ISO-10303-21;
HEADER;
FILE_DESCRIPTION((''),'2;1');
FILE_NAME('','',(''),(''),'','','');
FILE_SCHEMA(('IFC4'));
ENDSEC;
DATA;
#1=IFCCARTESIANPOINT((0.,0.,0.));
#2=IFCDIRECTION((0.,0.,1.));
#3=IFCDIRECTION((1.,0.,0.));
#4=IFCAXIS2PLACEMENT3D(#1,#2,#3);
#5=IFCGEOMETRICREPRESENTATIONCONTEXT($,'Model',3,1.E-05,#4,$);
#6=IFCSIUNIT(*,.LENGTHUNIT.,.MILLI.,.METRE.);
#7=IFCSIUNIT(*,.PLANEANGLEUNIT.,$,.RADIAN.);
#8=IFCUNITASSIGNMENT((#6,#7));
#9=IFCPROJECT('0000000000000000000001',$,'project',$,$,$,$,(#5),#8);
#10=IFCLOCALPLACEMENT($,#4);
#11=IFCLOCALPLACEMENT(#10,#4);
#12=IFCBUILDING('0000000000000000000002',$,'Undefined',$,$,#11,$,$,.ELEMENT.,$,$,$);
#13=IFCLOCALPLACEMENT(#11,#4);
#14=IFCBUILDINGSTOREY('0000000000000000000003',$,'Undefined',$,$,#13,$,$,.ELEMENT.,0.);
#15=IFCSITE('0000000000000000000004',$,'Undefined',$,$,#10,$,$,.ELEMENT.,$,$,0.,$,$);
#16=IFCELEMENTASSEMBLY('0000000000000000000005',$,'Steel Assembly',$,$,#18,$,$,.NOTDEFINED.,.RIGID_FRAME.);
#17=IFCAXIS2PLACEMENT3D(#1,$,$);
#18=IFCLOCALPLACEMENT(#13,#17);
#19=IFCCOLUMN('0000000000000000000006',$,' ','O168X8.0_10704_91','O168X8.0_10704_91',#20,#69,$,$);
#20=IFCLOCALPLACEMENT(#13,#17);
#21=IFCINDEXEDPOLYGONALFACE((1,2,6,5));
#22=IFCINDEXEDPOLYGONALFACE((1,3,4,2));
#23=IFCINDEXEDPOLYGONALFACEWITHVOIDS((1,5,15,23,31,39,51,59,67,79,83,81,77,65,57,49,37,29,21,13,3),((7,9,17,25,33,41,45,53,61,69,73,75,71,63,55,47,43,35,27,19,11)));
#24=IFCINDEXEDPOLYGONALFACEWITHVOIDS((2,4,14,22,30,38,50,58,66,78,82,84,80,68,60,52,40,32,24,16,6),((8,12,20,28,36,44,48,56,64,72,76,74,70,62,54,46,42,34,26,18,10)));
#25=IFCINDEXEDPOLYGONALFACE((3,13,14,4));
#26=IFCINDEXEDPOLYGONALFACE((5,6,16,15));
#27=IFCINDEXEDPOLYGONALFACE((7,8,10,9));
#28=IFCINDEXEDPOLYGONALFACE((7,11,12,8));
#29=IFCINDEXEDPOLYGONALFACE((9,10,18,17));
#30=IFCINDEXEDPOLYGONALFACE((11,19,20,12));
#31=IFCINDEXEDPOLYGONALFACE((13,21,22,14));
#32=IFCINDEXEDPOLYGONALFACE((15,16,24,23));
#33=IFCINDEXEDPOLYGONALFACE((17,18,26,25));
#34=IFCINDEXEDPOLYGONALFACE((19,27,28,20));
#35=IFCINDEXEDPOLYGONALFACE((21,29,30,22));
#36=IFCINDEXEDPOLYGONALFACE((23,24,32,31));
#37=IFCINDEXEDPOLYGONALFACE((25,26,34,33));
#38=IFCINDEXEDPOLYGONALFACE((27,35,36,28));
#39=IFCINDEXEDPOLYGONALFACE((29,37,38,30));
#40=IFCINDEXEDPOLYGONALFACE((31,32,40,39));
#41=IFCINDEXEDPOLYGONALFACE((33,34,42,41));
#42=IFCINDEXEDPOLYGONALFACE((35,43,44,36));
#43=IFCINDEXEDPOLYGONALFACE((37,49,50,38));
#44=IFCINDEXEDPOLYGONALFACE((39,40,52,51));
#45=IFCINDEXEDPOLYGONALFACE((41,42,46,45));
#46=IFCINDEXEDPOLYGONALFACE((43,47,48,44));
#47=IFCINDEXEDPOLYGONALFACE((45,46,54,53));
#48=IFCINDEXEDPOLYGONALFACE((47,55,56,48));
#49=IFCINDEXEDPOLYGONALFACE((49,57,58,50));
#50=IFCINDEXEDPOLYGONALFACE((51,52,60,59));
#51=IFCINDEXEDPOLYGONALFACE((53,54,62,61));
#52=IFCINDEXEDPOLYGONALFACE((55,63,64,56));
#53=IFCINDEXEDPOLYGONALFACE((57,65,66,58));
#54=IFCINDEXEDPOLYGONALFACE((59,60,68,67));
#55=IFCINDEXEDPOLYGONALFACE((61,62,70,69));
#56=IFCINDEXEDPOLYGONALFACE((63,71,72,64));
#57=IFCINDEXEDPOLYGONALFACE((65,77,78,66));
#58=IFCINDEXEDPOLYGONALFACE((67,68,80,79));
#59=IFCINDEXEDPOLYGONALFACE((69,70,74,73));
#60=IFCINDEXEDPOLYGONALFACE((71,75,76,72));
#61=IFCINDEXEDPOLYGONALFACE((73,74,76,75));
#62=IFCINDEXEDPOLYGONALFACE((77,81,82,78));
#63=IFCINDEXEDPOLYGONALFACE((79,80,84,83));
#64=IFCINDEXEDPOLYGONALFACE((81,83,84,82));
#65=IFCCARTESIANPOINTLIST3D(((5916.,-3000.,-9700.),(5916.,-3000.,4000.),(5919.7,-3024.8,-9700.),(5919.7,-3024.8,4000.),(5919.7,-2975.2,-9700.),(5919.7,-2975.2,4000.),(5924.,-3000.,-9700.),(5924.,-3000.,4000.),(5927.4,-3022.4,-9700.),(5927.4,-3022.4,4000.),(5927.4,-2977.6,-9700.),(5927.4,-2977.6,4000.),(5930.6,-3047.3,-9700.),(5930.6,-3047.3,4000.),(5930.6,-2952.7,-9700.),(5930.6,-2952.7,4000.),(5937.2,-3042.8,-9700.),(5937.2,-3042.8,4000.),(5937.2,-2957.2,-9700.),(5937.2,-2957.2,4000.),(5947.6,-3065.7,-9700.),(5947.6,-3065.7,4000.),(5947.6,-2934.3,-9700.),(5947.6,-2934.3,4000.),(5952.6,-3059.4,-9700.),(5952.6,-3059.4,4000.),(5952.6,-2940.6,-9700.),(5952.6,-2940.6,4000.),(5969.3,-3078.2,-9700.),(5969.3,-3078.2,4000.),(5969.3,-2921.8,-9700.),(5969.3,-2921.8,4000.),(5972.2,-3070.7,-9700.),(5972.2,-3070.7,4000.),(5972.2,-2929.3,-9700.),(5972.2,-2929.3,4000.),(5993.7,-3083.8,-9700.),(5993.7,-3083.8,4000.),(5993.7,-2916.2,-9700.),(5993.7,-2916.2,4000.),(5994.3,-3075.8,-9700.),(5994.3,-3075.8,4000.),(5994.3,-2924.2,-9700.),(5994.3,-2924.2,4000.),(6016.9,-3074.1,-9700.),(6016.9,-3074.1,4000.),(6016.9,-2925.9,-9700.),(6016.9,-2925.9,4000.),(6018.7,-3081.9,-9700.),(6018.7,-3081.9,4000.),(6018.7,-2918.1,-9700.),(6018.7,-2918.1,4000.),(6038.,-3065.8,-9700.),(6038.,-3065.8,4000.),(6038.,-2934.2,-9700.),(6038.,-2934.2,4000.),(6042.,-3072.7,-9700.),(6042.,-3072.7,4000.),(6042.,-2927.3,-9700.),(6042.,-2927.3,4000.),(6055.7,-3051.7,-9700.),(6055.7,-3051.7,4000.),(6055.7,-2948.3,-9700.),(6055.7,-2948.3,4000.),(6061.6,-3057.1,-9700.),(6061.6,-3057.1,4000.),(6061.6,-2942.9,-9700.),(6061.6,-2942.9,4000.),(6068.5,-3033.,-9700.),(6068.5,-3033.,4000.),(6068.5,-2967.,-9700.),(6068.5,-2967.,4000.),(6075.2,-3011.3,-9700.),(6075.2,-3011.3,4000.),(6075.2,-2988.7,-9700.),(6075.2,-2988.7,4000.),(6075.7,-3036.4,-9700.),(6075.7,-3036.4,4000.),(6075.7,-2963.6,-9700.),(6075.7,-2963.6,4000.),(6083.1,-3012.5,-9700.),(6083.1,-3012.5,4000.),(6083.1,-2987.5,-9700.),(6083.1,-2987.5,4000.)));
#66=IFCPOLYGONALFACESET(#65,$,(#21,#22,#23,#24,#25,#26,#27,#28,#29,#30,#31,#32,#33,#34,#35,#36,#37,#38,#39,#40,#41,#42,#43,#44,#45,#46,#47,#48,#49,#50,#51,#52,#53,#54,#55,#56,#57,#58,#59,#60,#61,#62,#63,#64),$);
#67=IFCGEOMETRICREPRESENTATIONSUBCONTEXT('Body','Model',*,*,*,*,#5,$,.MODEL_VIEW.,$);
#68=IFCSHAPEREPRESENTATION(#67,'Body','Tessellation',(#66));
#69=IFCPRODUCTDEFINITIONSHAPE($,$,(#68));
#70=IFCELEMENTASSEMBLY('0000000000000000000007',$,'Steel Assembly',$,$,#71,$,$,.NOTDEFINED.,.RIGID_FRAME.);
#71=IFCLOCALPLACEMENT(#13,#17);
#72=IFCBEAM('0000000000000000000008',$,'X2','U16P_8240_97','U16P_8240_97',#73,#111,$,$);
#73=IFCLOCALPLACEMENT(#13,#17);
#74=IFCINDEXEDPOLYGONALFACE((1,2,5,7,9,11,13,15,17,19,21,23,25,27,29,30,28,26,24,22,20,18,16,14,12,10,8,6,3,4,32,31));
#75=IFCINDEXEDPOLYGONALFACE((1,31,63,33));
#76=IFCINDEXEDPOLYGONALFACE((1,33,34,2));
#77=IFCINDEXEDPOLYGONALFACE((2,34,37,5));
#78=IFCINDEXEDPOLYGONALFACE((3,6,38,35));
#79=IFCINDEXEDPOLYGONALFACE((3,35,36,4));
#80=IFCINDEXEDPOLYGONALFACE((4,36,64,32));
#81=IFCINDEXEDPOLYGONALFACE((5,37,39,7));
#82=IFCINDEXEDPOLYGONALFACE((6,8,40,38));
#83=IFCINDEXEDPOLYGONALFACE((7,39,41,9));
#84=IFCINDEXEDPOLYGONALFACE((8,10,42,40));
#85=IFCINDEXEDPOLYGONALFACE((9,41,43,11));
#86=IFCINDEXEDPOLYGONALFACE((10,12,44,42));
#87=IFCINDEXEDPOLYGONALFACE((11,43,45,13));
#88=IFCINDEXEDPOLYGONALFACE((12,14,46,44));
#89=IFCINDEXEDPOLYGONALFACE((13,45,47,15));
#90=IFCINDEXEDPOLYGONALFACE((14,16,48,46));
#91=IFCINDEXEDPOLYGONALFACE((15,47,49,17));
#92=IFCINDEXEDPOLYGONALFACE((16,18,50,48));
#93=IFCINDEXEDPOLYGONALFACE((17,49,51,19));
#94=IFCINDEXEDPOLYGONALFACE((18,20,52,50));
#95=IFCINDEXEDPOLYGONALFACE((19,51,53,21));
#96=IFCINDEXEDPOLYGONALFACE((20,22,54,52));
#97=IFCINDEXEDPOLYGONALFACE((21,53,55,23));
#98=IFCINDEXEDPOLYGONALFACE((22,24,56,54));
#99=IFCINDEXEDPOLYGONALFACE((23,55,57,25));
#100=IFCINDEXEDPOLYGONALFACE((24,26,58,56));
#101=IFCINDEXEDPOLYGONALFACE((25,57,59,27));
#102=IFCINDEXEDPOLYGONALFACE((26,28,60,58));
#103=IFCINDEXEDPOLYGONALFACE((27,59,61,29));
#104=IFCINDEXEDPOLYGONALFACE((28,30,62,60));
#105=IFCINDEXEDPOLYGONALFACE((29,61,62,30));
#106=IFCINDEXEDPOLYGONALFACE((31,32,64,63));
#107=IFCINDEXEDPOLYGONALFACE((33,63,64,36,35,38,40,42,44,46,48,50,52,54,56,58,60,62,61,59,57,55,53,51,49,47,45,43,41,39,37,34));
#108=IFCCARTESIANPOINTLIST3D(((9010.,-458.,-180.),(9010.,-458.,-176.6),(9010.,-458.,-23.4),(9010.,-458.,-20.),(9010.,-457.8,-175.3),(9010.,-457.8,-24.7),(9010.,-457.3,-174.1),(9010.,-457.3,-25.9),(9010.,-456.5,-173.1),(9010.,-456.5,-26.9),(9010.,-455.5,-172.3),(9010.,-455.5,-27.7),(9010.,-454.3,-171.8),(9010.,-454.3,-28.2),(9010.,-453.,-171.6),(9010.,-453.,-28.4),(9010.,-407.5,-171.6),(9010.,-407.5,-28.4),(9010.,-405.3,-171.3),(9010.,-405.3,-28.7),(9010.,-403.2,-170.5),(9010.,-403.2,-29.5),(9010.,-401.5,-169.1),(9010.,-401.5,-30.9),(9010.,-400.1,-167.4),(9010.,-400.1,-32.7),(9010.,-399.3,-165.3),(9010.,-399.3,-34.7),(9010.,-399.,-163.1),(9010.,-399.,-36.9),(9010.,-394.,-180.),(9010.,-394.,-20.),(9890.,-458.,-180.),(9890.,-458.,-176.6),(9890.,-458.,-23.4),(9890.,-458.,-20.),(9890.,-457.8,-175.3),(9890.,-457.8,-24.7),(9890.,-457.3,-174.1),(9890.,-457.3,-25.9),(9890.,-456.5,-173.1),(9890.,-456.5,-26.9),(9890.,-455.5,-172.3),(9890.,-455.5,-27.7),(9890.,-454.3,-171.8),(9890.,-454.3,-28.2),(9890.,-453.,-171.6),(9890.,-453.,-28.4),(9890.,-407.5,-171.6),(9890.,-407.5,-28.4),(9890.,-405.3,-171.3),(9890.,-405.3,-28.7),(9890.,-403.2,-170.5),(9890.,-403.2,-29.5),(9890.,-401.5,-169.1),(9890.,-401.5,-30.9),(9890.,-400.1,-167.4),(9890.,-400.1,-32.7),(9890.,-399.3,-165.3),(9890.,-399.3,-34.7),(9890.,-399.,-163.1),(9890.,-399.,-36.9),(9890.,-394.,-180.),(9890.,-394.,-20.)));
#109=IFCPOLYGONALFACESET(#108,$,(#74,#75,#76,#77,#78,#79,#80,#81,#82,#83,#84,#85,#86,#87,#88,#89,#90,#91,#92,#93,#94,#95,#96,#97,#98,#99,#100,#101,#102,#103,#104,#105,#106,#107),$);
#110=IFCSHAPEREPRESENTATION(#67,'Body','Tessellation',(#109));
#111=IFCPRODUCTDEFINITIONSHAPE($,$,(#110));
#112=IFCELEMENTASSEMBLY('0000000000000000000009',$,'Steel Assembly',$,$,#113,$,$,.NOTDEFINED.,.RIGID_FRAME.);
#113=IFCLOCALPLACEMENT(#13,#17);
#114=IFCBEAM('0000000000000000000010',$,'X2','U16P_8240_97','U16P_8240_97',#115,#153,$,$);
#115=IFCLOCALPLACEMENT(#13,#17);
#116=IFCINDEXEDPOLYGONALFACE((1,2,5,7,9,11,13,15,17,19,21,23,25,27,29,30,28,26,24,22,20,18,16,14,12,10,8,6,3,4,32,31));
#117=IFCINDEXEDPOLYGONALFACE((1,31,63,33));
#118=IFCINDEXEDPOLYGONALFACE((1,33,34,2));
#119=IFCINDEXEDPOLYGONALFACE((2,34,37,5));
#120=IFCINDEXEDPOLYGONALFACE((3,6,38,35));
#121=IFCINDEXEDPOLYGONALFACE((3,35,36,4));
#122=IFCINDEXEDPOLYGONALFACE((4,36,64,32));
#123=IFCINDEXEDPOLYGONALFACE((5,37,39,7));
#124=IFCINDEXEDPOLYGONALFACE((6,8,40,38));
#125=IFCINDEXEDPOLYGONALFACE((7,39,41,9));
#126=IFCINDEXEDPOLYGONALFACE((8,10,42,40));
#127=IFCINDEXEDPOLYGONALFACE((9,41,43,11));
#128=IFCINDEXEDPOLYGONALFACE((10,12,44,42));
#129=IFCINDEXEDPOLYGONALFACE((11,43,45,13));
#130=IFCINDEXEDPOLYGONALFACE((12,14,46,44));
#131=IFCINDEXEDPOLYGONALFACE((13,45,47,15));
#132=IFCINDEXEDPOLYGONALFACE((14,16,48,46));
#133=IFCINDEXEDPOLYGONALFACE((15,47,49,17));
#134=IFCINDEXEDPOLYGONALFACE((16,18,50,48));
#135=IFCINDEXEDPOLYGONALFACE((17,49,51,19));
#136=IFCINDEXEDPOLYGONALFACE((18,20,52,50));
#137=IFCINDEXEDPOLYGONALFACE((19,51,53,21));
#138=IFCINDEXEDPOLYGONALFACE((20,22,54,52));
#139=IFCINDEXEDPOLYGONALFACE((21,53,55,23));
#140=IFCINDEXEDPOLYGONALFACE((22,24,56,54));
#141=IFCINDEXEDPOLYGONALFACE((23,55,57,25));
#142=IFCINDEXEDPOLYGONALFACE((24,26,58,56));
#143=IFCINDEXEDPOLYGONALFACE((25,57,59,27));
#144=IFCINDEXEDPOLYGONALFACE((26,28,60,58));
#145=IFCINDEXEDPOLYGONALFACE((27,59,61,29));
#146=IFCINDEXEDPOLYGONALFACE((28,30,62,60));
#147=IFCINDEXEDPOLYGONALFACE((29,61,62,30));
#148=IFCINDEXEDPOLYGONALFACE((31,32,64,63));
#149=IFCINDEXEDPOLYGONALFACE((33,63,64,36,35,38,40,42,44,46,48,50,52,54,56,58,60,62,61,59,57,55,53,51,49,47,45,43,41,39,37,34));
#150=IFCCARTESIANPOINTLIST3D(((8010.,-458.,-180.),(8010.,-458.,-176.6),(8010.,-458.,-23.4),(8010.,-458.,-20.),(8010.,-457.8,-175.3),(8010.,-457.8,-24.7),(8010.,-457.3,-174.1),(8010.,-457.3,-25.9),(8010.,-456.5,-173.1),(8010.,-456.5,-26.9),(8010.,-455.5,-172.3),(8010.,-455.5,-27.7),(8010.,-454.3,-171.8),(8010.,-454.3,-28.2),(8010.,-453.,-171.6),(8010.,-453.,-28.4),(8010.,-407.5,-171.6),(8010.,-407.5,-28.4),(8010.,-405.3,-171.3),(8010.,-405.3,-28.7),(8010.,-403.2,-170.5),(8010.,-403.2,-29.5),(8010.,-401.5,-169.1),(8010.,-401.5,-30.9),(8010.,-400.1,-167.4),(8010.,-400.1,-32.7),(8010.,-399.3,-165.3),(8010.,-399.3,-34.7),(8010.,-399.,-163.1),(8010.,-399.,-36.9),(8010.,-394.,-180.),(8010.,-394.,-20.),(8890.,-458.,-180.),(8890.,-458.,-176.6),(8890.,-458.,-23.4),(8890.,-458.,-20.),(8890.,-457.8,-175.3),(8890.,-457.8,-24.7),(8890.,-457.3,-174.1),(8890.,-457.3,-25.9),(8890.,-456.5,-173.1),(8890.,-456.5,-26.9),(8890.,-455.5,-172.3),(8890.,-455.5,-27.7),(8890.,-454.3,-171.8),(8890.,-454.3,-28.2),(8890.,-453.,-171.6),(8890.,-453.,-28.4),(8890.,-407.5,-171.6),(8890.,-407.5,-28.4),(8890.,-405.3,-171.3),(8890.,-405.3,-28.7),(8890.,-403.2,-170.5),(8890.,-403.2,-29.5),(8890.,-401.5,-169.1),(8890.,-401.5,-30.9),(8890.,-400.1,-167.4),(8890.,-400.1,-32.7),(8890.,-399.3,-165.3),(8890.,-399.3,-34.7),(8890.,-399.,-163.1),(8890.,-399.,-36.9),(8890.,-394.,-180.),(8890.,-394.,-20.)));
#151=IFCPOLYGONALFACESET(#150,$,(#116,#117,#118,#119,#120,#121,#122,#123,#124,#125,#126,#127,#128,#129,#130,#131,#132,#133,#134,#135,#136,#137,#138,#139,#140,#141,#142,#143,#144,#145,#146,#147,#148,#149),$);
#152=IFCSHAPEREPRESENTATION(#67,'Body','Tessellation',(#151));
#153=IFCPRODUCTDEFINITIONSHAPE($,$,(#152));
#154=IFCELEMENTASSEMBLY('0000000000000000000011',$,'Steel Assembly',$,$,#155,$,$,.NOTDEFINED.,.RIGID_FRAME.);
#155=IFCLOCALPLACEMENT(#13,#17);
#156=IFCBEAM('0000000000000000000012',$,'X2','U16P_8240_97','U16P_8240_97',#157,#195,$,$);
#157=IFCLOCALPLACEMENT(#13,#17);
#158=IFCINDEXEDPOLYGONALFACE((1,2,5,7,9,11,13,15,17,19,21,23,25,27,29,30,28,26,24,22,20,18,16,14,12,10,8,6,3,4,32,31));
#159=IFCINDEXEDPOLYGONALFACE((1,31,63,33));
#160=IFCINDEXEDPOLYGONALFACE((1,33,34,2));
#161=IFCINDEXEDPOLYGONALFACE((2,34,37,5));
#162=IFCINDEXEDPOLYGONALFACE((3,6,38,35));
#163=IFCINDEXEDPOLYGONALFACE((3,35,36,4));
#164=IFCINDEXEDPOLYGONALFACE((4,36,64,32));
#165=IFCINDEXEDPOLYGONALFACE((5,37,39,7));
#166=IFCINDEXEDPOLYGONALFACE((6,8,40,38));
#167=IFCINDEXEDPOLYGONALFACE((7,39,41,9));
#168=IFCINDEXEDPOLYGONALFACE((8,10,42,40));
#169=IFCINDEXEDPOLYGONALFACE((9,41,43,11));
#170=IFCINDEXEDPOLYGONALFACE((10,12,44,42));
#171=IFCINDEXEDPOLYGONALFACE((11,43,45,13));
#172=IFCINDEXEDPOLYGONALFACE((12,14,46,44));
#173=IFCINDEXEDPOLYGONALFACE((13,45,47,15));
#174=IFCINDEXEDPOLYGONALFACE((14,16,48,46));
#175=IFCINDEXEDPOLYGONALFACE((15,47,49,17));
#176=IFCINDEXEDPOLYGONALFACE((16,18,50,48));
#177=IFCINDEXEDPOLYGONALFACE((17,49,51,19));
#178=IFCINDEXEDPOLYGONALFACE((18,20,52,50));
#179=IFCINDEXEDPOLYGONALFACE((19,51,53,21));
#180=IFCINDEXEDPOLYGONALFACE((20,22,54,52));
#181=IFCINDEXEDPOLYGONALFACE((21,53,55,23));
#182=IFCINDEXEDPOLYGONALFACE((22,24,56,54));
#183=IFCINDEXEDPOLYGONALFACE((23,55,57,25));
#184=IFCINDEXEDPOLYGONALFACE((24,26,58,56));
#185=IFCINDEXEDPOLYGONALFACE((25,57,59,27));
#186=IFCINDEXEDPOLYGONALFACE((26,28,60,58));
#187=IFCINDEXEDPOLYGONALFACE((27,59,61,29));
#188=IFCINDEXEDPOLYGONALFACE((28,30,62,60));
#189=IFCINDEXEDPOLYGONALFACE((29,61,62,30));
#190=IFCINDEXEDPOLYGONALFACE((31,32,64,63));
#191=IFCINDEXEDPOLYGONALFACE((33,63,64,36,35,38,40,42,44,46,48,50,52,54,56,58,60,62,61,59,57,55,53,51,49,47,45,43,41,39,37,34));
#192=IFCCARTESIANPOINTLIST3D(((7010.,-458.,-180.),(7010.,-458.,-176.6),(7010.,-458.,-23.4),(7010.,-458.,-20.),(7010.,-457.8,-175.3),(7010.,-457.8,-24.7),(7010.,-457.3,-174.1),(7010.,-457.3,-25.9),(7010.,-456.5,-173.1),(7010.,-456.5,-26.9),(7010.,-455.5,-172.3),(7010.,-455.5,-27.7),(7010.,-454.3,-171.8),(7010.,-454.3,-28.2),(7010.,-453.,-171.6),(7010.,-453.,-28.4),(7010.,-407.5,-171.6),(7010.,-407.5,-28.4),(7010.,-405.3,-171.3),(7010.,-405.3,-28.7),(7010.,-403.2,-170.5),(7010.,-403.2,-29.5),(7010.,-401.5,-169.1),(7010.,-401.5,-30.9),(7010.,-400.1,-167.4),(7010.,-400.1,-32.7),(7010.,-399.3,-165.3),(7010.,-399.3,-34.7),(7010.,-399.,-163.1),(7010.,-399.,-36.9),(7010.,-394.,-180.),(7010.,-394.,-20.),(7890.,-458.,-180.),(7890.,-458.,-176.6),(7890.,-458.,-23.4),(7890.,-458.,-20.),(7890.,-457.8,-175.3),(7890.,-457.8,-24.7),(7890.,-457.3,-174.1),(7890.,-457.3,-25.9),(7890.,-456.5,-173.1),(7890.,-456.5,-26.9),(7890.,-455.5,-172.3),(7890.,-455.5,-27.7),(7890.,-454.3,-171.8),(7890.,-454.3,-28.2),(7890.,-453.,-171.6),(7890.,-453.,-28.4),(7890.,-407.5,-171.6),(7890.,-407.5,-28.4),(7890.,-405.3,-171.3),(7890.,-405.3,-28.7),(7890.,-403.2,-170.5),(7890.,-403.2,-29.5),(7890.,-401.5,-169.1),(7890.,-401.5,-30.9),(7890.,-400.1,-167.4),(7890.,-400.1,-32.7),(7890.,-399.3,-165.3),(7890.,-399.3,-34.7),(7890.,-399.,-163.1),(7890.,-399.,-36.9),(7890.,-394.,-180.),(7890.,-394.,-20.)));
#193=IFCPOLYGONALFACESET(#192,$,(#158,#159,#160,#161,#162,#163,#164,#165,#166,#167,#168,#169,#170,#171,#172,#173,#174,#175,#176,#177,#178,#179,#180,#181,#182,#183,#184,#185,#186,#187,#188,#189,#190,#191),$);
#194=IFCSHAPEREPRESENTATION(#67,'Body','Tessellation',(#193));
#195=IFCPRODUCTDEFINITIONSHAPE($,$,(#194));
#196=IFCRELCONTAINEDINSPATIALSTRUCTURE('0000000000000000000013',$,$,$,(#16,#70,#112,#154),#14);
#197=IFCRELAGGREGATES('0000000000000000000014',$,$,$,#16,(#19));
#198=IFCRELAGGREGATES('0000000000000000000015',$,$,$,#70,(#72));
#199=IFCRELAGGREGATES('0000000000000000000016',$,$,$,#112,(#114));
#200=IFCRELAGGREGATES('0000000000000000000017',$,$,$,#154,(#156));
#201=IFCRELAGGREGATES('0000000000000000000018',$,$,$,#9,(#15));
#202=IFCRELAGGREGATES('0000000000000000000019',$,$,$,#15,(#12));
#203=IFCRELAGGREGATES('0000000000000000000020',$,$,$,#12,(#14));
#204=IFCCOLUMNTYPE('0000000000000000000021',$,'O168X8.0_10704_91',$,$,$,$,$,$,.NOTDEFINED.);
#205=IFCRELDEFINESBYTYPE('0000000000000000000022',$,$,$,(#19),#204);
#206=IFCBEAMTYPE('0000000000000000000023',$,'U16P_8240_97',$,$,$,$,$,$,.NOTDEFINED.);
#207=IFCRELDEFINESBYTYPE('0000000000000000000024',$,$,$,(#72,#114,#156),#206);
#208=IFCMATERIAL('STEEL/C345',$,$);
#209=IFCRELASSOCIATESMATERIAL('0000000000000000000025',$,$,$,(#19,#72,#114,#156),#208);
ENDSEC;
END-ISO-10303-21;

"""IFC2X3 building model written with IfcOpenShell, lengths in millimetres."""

from ifc_helpers import new_model, si_unit, frame, origin_with_axes, origin_2d_with_axis, place, context, subcontext, project, spatial, hollow_circle, u_section, extrude, material, type_object, element, aggregate, save


model = new_model("IFC2X3")

# Units and contexts
model_context = context("Model", 3, precision=1e-05, world=origin_with_axes())
body_context = subcontext(model_context, "Body", "Model", "MODEL_VIEW")
ifc_project = project(units=[si_unit("LENGTHUNIT", "METRE", prefix="MILLI"), si_unit("PLANEANGLEUNIT", "RADIAN")], contexts=[model_context])

# Site, building, storey
site_placement = place(None, origin_with_axes())
site = spatial("IfcSite", under=ifc_project, at=site_placement, Name="Undefined", CompositionType="ELEMENT", RefElevation=0.0)
building_placement = place(site_placement, origin_with_axes())
building = spatial("IfcBuilding", under=site, at=building_placement, Name="Undefined", CompositionType="ELEMENT")
storey_placement = place(building_placement, origin_with_axes())
storey = spatial("IfcBuildingStorey", under=building, at=storey_placement, Name="Undefined", CompositionType="ELEMENT", Elevation=0.0)

# Element assembly, column
ifc_material_1 = material(Name="STEEL/C345")
assembly_1_placement = place(storey_placement, origin_with_axes())
assembly_1 = element("IfcElementAssembly", 1, at=assembly_1_placement, inside=storey, Name="Steel Assembly", AssemblyPlace="NOTDEFINED", PredefinedType="RIGID_FRAME")
column_type_1 = type_object("IfcColumnType", Name="O168X8.0_10704_91", PredefinedType="NOTDEFINED")
column_1_placement = place(assembly_1_placement, frame((6000.0, -3000.0, -9700.0), z_axis=(0.0, 0.0, 1.0), x_axis=(0.0, 1.0, 0.0)))
column_1 = element("IfcColumn", 2, at=column_1_placement, type_object=column_type_1, material=ifc_material_1, Name=" ", Description="O168X8.0_10704_91", ObjectType="O168X8.0_10704_91", context=body_context, shape_type="SweptSolid", body=[
    extrude(hollow_circle(Radius=84.0, WallThickness=8.0, at=origin_2d_with_axis()), frame((0.0, 0.0, 13700.0), z_axis=(0.0, 0.0, -1.0), x_axis=(0.0, 1.0, 0.0)), (0.0, 0.0, 1.0), 13700.0),
])
aggregate(assembly_1, [column_1])

# Element assemblies, beams
assembly_2_placement = place(storey_placement, origin_with_axes())
assembly_2 = element("IfcElementAssembly", 3, at=assembly_2_placement, inside=storey, Name="Steel Assembly", AssemblyPlace="NOTDEFINED", PredefinedType="RIGID_FRAME")
beam_type_1 = type_object("IfcBeamType", Name="U16P_8240_97", PredefinedType="NOTDEFINED")
beam_1_placement = place(assembly_2_placement, frame((9890.0, -426.0, -100.0), z_axis=(0.0, 0.0, -1.0), x_axis=(-1.0, 0.0, 0.0)))
beam_1 = element("IfcBeam", 4, at=beam_1_placement, type_object=beam_type_1, material=ifc_material_1, Name="X2", Description="U16P_8240_97", ObjectType="U16P_8240_97", context=body_context, shape_type="SweptSolid", body=[
    extrude(u_section(Depth=160.0, FlangeWidth=64.0, WebThickness=5.0, FlangeThickness=8.4, FilletRadius=8.5, EdgeRadius=5.0, at=origin_2d_with_axis()), frame((880.0, 0.0, 0.0), z_axis=(-1.0, 0.0, 0.0), x_axis=(0.0, -1.0, 0.0)), (0.0, 0.0, 1.0), 880.0),
])
aggregate(assembly_2, [beam_1])
assembly_3_placement = place(storey_placement, origin_with_axes())
assembly_3 = element("IfcElementAssembly", 5, at=assembly_3_placement, inside=storey, Name="Steel Assembly", AssemblyPlace="NOTDEFINED", PredefinedType="RIGID_FRAME")
beam_2_placement = place(assembly_3_placement, frame((8890.0, -426.0, -100.0), z_axis=(0.0, 0.0, -1.0), x_axis=(-1.0, 0.0, 0.0)))
beam_2 = element("IfcBeam", 6, at=beam_2_placement, type_object=beam_type_1, material=ifc_material_1, Name="X2", Description="U16P_8240_97", ObjectType="U16P_8240_97", context=body_context, shape_type="SweptSolid", body=[
    extrude(u_section(Depth=160.0, FlangeWidth=64.0, WebThickness=5.0, FlangeThickness=8.4, FilletRadius=8.5, EdgeRadius=5.0, at=origin_2d_with_axis()), frame((880.0, 0.0, 0.0), z_axis=(-1.0, 0.0, 0.0), x_axis=(0.0, -1.0, 0.0)), (0.0, 0.0, 1.0), 880.0),
])
aggregate(assembly_3, [beam_2])
assembly_4_placement = place(storey_placement, origin_with_axes())
assembly_4 = element("IfcElementAssembly", 7, at=assembly_4_placement, inside=storey, Name="Steel Assembly", AssemblyPlace="NOTDEFINED", PredefinedType="RIGID_FRAME")
beam_3_placement = place(assembly_4_placement, frame((7890.0, -426.0, -100.0), z_axis=(0.0, 0.0, -1.0), x_axis=(-1.0, 0.0, 0.0)))
beam_3 = element("IfcBeam", 8, at=beam_3_placement, type_object=beam_type_1, material=ifc_material_1, Name="X2", Description="U16P_8240_97", ObjectType="U16P_8240_97", context=body_context, shape_type="SweptSolid", body=[
    extrude(u_section(Depth=160.0, FlangeWidth=64.0, WebThickness=5.0, FlangeThickness=8.4, FilletRadius=8.5, EdgeRadius=5.0, at=origin_2d_with_axis()), frame((880.0, 0.0, 0.0), z_axis=(-1.0, 0.0, 0.0), x_axis=(0.0, -1.0, 0.0)), (0.0, 0.0, 1.0), 880.0),
])
aggregate(assembly_4, [beam_3])

save(model, "model.ifc")
